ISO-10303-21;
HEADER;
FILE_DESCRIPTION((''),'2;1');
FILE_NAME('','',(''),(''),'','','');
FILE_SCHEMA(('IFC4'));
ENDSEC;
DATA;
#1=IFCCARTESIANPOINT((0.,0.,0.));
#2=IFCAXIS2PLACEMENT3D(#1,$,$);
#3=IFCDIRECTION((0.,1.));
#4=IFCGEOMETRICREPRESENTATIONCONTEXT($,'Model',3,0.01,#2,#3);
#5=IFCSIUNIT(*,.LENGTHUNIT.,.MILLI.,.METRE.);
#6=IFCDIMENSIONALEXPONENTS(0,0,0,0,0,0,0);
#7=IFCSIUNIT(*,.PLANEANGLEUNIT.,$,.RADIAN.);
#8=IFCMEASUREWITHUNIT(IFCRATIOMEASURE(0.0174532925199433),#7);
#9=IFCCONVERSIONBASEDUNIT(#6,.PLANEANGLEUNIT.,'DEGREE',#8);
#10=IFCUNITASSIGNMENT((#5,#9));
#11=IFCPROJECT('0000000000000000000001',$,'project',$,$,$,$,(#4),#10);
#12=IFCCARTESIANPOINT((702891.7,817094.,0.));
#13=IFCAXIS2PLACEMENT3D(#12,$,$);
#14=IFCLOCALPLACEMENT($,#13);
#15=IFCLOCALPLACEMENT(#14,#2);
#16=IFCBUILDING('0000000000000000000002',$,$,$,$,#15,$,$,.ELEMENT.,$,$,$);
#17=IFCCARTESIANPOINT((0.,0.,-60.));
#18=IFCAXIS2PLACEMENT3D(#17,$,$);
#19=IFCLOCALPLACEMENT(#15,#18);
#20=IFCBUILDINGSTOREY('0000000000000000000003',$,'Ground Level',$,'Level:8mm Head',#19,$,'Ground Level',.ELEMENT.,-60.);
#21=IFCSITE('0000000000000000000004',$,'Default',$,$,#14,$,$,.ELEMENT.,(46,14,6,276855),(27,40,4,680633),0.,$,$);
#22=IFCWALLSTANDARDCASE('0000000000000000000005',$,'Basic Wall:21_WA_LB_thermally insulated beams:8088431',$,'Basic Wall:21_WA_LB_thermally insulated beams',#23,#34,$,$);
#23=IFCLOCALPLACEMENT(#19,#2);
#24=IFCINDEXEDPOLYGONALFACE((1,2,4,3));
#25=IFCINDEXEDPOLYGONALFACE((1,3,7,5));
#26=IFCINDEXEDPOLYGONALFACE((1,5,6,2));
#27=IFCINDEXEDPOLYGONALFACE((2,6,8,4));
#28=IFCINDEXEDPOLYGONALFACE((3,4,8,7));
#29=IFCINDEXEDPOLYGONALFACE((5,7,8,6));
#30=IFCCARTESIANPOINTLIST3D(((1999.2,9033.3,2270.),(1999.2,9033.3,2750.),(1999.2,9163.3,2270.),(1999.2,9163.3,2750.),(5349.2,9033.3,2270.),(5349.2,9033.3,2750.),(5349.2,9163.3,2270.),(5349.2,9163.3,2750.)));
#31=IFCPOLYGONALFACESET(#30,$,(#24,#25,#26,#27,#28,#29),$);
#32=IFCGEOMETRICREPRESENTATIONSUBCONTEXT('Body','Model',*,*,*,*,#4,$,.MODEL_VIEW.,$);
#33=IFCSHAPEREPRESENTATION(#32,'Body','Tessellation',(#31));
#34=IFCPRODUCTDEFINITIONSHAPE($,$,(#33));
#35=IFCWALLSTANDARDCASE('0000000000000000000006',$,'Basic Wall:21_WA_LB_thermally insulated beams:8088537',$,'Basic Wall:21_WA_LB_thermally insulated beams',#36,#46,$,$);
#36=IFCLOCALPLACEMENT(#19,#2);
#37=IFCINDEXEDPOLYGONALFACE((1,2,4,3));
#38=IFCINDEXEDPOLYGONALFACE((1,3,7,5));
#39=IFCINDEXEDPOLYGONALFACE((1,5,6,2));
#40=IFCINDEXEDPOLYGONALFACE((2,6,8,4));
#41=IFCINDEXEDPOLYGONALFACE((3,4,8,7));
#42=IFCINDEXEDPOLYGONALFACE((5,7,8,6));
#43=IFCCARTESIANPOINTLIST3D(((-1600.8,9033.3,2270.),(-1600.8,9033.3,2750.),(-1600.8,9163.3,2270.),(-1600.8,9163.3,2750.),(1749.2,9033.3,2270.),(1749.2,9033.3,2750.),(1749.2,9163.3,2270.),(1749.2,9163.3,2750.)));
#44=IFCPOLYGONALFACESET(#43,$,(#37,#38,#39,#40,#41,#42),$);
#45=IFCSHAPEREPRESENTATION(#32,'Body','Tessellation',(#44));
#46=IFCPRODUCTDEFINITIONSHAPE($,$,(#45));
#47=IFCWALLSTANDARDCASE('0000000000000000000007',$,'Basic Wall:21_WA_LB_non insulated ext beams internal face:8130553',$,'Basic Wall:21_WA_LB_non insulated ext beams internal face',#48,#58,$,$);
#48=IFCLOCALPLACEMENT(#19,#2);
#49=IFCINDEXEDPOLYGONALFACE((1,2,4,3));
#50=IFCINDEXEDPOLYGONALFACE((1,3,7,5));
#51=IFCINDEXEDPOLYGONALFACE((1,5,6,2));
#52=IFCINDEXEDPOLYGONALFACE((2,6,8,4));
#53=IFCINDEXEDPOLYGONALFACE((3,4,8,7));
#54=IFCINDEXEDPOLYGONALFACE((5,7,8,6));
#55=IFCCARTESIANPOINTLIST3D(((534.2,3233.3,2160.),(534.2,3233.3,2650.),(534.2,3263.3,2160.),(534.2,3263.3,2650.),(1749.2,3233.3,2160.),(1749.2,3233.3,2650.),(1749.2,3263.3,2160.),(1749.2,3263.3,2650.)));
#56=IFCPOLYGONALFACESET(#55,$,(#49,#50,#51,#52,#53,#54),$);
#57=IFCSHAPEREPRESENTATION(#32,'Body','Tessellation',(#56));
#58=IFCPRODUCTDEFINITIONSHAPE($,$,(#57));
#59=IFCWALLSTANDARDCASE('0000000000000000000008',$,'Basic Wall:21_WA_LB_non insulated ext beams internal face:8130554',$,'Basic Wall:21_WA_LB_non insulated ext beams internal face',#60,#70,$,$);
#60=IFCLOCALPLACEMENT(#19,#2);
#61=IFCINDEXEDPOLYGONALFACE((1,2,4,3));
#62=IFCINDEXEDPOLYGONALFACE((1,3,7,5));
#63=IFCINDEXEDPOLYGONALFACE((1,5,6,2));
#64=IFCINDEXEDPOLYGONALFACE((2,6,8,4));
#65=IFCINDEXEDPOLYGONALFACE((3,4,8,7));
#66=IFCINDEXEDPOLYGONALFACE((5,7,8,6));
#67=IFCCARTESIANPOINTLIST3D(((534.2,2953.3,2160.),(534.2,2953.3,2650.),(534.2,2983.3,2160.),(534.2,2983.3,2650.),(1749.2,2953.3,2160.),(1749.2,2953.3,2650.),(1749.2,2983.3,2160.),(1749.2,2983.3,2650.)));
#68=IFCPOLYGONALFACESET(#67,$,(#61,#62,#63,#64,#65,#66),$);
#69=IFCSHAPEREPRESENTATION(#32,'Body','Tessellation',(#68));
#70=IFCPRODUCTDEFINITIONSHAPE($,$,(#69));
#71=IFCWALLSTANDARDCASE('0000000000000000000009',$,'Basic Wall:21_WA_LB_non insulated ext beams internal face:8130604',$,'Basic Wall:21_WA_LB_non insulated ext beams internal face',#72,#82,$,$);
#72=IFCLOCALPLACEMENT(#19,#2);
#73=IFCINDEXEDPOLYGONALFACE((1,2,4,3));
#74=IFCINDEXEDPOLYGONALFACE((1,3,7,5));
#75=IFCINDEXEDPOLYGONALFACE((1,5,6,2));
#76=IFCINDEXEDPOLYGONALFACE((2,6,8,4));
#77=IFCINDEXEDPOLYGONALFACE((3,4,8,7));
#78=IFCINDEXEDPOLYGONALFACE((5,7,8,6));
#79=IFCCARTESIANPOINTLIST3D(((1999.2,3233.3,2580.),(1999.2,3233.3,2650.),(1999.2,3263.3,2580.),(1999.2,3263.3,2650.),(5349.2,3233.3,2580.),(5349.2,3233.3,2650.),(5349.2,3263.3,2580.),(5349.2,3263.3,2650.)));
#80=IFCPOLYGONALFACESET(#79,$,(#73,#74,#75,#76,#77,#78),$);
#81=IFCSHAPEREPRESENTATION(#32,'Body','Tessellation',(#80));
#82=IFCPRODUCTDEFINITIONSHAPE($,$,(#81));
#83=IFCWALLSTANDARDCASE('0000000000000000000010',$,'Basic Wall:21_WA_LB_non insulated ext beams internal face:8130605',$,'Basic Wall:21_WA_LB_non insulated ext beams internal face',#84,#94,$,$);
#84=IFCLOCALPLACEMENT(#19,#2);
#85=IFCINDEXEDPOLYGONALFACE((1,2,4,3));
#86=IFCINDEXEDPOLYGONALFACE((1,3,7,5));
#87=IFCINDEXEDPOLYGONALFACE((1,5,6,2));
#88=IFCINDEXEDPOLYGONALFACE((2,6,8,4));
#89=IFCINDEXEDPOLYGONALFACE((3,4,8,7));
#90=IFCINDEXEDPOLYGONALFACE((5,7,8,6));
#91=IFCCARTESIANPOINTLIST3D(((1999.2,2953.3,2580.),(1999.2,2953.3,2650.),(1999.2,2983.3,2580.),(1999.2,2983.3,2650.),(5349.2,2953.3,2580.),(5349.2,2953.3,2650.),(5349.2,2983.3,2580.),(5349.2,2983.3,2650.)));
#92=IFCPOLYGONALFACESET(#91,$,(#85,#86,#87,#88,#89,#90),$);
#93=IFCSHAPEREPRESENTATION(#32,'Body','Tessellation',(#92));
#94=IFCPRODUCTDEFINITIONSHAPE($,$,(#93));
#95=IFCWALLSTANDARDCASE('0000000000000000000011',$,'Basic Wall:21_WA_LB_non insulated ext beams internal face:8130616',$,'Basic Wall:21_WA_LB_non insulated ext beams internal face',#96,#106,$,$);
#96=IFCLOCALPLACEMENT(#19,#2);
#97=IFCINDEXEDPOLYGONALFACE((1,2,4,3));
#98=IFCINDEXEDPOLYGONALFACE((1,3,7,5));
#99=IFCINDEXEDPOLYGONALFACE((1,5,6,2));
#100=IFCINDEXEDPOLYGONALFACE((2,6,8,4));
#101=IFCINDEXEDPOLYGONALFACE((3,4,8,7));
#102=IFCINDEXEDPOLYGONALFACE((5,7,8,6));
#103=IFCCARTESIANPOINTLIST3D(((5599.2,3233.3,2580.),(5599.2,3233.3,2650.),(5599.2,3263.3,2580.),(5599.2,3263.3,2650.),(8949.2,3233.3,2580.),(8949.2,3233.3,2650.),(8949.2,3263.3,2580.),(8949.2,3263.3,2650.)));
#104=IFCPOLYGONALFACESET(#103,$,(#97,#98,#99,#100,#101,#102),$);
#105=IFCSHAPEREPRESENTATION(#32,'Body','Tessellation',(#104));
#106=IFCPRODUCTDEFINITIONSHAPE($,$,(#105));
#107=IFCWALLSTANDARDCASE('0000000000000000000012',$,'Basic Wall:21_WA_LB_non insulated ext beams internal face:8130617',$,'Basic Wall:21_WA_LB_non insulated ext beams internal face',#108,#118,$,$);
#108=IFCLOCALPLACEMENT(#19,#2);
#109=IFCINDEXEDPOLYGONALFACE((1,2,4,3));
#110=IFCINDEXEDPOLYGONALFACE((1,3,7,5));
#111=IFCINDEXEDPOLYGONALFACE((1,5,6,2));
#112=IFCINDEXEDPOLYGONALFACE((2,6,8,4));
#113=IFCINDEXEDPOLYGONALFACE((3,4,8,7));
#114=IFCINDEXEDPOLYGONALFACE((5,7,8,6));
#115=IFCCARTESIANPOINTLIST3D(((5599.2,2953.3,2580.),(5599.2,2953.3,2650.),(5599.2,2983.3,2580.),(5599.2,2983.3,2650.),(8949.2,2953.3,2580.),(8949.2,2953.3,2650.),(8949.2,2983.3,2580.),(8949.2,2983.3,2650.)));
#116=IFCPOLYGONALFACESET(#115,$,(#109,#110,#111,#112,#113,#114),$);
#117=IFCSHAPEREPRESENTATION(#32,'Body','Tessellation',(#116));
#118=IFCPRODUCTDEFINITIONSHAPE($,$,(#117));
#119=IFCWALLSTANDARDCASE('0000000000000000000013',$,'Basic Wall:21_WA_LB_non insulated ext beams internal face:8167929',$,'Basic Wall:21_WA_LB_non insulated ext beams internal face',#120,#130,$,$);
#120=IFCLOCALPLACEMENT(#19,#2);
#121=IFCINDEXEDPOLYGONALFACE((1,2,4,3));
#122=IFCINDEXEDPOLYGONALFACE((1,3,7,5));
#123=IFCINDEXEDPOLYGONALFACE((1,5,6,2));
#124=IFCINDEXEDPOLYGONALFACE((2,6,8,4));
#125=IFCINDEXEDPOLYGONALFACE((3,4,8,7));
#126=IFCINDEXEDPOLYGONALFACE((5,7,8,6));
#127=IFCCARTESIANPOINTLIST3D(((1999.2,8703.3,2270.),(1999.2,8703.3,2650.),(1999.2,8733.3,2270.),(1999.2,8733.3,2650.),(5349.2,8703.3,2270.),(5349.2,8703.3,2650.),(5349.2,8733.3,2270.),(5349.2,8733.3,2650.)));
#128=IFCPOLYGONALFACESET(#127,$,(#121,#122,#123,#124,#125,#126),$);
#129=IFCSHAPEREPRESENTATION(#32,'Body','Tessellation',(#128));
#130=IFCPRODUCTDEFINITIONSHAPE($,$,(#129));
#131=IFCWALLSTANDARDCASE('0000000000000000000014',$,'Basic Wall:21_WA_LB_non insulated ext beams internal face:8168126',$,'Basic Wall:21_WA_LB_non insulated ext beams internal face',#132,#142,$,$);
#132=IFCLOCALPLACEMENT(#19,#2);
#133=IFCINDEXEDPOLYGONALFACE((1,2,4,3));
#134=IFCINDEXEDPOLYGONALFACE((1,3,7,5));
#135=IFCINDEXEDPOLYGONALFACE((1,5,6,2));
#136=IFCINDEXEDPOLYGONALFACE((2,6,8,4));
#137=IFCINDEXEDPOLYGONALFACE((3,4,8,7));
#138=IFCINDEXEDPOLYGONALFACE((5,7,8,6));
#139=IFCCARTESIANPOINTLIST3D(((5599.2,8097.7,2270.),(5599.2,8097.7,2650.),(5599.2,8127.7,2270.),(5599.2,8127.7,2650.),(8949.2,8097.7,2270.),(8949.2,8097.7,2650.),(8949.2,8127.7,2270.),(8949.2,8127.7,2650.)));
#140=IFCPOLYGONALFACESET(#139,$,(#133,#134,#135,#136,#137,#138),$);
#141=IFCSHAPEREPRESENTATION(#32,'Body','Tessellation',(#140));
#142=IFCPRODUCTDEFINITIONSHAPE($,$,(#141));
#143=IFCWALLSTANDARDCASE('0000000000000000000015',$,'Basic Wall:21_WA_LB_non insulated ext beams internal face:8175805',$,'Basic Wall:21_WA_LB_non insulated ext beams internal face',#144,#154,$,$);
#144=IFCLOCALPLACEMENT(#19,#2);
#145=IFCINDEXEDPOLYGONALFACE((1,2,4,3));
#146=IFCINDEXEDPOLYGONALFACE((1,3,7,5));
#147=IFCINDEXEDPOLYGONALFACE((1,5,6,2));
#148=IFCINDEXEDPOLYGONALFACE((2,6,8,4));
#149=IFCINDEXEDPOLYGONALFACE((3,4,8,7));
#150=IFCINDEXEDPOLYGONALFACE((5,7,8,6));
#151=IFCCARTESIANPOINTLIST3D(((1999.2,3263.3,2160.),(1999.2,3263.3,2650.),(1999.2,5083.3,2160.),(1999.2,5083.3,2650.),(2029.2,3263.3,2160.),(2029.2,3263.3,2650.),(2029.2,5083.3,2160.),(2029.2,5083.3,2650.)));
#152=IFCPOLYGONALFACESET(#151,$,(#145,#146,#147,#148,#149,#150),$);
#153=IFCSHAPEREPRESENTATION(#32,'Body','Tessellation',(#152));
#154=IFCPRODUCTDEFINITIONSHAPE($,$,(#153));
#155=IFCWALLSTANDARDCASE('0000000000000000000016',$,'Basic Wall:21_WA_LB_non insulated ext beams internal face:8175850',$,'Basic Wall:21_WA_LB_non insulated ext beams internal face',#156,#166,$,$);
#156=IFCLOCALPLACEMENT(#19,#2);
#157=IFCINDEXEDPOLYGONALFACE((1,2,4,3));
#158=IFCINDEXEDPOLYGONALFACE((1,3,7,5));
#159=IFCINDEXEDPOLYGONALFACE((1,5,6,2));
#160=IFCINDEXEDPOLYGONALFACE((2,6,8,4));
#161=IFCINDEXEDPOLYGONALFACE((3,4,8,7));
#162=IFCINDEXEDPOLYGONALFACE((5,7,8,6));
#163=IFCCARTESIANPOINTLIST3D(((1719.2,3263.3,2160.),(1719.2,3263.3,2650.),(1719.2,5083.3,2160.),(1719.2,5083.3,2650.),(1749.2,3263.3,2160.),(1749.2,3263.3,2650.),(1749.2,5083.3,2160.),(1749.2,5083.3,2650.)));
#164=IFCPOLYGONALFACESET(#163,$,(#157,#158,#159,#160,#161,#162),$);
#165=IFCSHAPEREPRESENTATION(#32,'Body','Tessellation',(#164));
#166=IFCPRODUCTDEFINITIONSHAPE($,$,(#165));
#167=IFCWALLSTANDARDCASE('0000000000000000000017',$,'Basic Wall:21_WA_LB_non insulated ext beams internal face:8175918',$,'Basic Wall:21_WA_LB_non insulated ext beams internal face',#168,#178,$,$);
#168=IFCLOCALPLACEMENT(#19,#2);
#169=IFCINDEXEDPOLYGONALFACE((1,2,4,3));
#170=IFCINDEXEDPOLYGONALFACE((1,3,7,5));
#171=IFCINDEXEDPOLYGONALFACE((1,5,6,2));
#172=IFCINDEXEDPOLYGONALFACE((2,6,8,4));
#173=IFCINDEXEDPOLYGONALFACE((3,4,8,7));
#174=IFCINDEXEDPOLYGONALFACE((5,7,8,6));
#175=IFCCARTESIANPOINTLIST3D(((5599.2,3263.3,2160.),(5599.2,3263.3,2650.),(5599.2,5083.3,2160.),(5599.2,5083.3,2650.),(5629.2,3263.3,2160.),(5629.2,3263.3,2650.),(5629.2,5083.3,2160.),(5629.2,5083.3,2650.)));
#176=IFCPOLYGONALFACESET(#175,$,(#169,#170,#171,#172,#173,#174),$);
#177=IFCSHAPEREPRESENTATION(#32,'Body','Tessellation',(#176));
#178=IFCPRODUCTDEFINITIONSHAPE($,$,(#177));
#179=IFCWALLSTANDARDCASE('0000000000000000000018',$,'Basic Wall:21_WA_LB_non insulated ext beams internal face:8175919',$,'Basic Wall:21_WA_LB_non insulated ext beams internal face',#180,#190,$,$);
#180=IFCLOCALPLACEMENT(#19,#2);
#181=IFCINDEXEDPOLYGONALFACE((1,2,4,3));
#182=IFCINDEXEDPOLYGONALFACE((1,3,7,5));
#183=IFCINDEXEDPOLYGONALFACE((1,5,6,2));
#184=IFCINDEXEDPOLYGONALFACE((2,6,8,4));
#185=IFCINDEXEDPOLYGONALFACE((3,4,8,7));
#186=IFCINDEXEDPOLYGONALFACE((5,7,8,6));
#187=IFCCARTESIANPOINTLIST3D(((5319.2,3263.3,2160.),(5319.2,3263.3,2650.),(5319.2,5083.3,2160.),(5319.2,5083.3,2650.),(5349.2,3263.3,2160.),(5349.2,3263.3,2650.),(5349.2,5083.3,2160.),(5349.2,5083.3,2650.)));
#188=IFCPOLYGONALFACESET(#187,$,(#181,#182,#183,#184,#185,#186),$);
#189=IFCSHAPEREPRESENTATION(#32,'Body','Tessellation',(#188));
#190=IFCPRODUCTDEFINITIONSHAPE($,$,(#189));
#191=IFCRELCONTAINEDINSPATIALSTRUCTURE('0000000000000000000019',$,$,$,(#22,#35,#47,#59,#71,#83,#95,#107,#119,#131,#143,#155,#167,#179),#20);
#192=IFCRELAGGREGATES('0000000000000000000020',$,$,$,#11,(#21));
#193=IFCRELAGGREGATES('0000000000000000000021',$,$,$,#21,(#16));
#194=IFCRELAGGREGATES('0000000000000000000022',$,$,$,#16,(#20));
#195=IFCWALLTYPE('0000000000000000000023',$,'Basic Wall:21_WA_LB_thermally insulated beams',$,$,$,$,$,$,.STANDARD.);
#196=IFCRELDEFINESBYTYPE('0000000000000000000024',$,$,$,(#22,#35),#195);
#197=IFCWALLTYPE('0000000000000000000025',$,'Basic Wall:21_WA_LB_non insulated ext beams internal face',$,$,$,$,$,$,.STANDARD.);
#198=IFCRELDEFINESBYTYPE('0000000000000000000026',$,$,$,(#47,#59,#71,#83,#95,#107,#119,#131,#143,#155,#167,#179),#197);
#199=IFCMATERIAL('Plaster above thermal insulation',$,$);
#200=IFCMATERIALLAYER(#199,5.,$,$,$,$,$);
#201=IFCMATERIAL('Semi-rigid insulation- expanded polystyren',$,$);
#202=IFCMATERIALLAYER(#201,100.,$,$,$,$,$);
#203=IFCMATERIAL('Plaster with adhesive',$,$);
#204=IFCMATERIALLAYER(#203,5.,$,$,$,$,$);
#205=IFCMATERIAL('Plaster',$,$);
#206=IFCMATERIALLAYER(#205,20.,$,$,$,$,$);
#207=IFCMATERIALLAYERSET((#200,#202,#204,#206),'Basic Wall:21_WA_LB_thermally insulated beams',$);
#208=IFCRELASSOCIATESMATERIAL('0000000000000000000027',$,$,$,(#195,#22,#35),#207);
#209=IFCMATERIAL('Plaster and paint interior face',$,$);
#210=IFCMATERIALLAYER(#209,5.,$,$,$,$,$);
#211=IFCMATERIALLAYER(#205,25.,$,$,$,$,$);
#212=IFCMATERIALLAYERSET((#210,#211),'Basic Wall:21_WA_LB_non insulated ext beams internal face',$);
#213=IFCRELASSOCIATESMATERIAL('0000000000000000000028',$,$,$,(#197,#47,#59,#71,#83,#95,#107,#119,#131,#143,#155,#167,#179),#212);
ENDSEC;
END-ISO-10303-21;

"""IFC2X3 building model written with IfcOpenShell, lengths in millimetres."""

from ifc_helpers import new_model, entity, si_unit, converted_unit, direction, frame, frame_2d, origin, place, context, subcontext, project, spatial, rectangle, extrude, material, layer, layer_set, layer_usage, type_object, element, save


model = new_model("IFC2X3")

# Units and contexts
model_context = context("Model", 3, precision=0.01, world=origin(), true_north=direction((0.0, 1.0)))
body_context = subcontext(model_context, "Body", "Model", "MODEL_VIEW")
ifc_project = project(units=[si_unit("LENGTHUNIT", "METRE", prefix="MILLI"), converted_unit("PLANEANGLEUNIT", "DEGREE", entity("IfcRatioMeasure", 0.0174532925199433), si_unit("PLANEANGLEUNIT", "RADIAN"), dimensions=[0, 0, 0, 0, 0, 0, 0])], contexts=[model_context])

# Site, building, storey
site_placement = place(None, frame((702891.7, 817094.0, 0.0)))
site = spatial("IfcSite", under=ifc_project, at=site_placement, Name="Default", CompositionType="ELEMENT", RefLatitude=(46, 14, 6, 276855), RefLongitude=(27, 40, 4, 680633), RefElevation=0.0)
building_placement = place(site_placement, origin())
building = spatial("IfcBuilding", under=site, at=building_placement, CompositionType="ELEMENT")
storey_placement = place(building_placement, frame((0.0, 0.0, -60.0)))
storey = spatial("IfcBuildingStorey", under=building, at=storey_placement, Name="Ground Level", ObjectType="Level:8mm Head", LongName="Ground Level", CompositionType="ELEMENT", Elevation=-60.0)

# Walls
ifc_material_1 = material(Name="Plaster above thermal insulation")
ifc_layer_1 = layer(ifc_material_1, 5.0)
ifc_material_2 = material(Name="Semi-rigid insulation- expanded polystyren")
ifc_layer_2 = layer(ifc_material_2, 100.0)
ifc_material_3 = material(Name="Plaster with adhesive")
ifc_layer_3 = layer(ifc_material_3, 5.0)
ifc_material_4 = material(Name="Plaster")
ifc_layer_4 = layer(ifc_material_4, 20.0)
ifc_layer_set_1 = layer_set([ifc_layer_1, ifc_layer_2, ifc_layer_3, ifc_layer_4], Name="Basic Wall:21_WA_LB_thermally insulated beams")
ifc_layer_usage_1 = layer_usage(ifc_layer_set_1, "AXIS2", "POSITIVE", -65.0)
wall_type_1 = type_object("IfcWallType", Name="Basic Wall:21_WA_LB_thermally insulated beams", PredefinedType="STANDARD", material=ifc_layer_set_1)
wall_1_placement = place(storey_placement, frame((5349.2, 9098.3, 2270.0), z_axis=(0.0, 0.0, 1.0), x_axis=(-1.0, 0.0, 0.0)))
element("IfcWallStandardCase", 1, at=wall_1_placement, inside=storey, type_object=wall_type_1, material=ifc_layer_usage_1, Name="Basic Wall:21_WA_LB_thermally insulated beams:8088431", ObjectType="Basic Wall:21_WA_LB_thermally insulated beams", context=body_context, shape_type="SweptSolid", body=[
    extrude(rectangle(XDim=3350.0, YDim=130.0, at=frame_2d((1675.0, 0.0), x_axis=(-1.0, 0.0))), origin(), (0.0, 0.0, 1.0), 480.0),
])
ifc_layer_usage_2 = layer_usage(ifc_layer_set_1, "AXIS2", "POSITIVE", -65.0)
wall_2_placement = place(storey_placement, frame((1749.2, 9098.3, 2270.0), z_axis=(0.0, 0.0, 1.0), x_axis=(-1.0, 0.0, 0.0)))
element("IfcWallStandardCase", 2, at=wall_2_placement, inside=storey, type_object=wall_type_1, material=ifc_layer_usage_2, Name="Basic Wall:21_WA_LB_thermally insulated beams:8088537", ObjectType="Basic Wall:21_WA_LB_thermally insulated beams", context=body_context, shape_type="SweptSolid", body=[
    extrude(rectangle(XDim=3350.0, YDim=130.0, at=frame_2d((1675.0, 0.0), x_axis=(-1.0, 0.0))), origin(), (0.0, 0.0, 1.0), 480.0),
])
ifc_material_5 = material(Name="Plaster and paint interior face")
ifc_layer_5 = layer(ifc_material_5, 5.0)
ifc_layer_6 = layer(ifc_material_4, 25.0)
ifc_layer_set_2 = layer_set([ifc_layer_5, ifc_layer_6], Name="Basic Wall:21_WA_LB_non insulated ext beams internal face")
ifc_layer_usage_3 = layer_usage(ifc_layer_set_2, "AXIS2", "NEGATIVE", 15.0)
wall_type_2 = type_object("IfcWallType", Name="Basic Wall:21_WA_LB_non insulated ext beams internal face", PredefinedType="STANDARD", material=ifc_layer_set_2)
wall_3_placement = place(storey_placement, frame((534.2, 3248.3, 2160.0)))
element("IfcWallStandardCase", 3, at=wall_3_placement, inside=storey, type_object=wall_type_2, material=ifc_layer_usage_3, Name="Basic Wall:21_WA_LB_non insulated ext beams internal face:8130553", ObjectType="Basic Wall:21_WA_LB_non insulated ext beams internal face", context=body_context, shape_type="SweptSolid", body=[
    extrude(rectangle(XDim=1215.0, YDim=30.0, at=frame_2d((607.5, 0.0), x_axis=(-1.0, 0.0))), origin(), (0.0, 0.0, 1.0), 490.0),
])
ifc_layer_usage_4 = layer_usage(ifc_layer_set_2, "AXIS2", "POSITIVE", -15.0)
wall_4_placement = place(storey_placement, frame((534.2, 2968.3, 2160.0)))
element("IfcWallStandardCase", 4, at=wall_4_placement, inside=storey, type_object=wall_type_2, material=ifc_layer_usage_4, Name="Basic Wall:21_WA_LB_non insulated ext beams internal face:8130554", ObjectType="Basic Wall:21_WA_LB_non insulated ext beams internal face", context=body_context, shape_type="SweptSolid", body=[
    extrude(rectangle(XDim=1215.0, YDim=30.0, at=frame_2d((607.5, 0.0), x_axis=(-1.0, 0.0))), origin(), (0.0, 0.0, 1.0), 490.0),
])
ifc_layer_usage_5 = layer_usage(ifc_layer_set_2, "AXIS2", "NEGATIVE", 15.0)
wall_5_placement = place(storey_placement, frame((1999.2, 3248.3, 2580.0)))
element("IfcWallStandardCase", 5, at=wall_5_placement, inside=storey, type_object=wall_type_2, material=ifc_layer_usage_5, Name="Basic Wall:21_WA_LB_non insulated ext beams internal face:8130604", ObjectType="Basic Wall:21_WA_LB_non insulated ext beams internal face", context=body_context, shape_type="SweptSolid", body=[
    extrude(rectangle(XDim=3350.0, YDim=30.0, at=frame_2d((1675.0, 0.0), x_axis=(-1.0, 0.0))), origin(), (0.0, 0.0, 1.0), 70.0),
])
ifc_layer_usage_6 = layer_usage(ifc_layer_set_2, "AXIS2", "POSITIVE", -15.0)
wall_6_placement = place(storey_placement, frame((1999.2, 2968.3, 2580.0)))
element("IfcWallStandardCase", 6, at=wall_6_placement, inside=storey, type_object=wall_type_2, material=ifc_layer_usage_6, Name="Basic Wall:21_WA_LB_non insulated ext beams internal face:8130605", ObjectType="Basic Wall:21_WA_LB_non insulated ext beams internal face", context=body_context, shape_type="SweptSolid", body=[
    extrude(rectangle(XDim=3350.0, YDim=30.0, at=frame_2d((1675.0, 0.0), x_axis=(-1.0, 0.0))), origin(), (0.0, 0.0, 1.0), 70.0),
])
ifc_layer_usage_7 = layer_usage(ifc_layer_set_2, "AXIS2", "NEGATIVE", 15.0)
wall_7_placement = place(storey_placement, frame((5599.2, 3248.3, 2580.0)))
element("IfcWallStandardCase", 7, at=wall_7_placement, inside=storey, type_object=wall_type_2, material=ifc_layer_usage_7, Name="Basic Wall:21_WA_LB_non insulated ext beams internal face:8130616", ObjectType="Basic Wall:21_WA_LB_non insulated ext beams internal face", context=body_context, shape_type="SweptSolid", body=[
    extrude(rectangle(XDim=3350.0, YDim=30.0, at=frame_2d((1675.0, 0.0), x_axis=(-1.0, 0.0))), origin(), (0.0, 0.0, 1.0), 70.0),
])
ifc_layer_usage_8 = layer_usage(ifc_layer_set_2, "AXIS2", "POSITIVE", -15.0)
wall_8_placement = place(storey_placement, frame((5599.2, 2968.3, 2580.0)))
element("IfcWallStandardCase", 8, at=wall_8_placement, inside=storey, type_object=wall_type_2, material=ifc_layer_usage_8, Name="Basic Wall:21_WA_LB_non insulated ext beams internal face:8130617", ObjectType="Basic Wall:21_WA_LB_non insulated ext beams internal face", context=body_context, shape_type="SweptSolid", body=[
    extrude(rectangle(XDim=3350.0, YDim=30.0, at=frame_2d((1675.0, 0.0), x_axis=(-1.0, 0.0))), origin(), (0.0, 0.0, 1.0), 70.0),
])
ifc_layer_usage_9 = layer_usage(ifc_layer_set_2, "AXIS2", "POSITIVE", -15.0)
wall_9_placement = place(storey_placement, frame((1999.2, 8718.3, 2270.0)))
element("IfcWallStandardCase", 9, at=wall_9_placement, inside=storey, type_object=wall_type_2, material=ifc_layer_usage_9, Name="Basic Wall:21_WA_LB_non insulated ext beams internal face:8167929", ObjectType="Basic Wall:21_WA_LB_non insulated ext beams internal face", context=body_context, shape_type="SweptSolid", body=[
    extrude(rectangle(XDim=3350.0, YDim=30.0, at=frame_2d((1675.0, 0.0), x_axis=(-1.0, 0.0))), origin(), (0.0, 0.0, 1.0), 380.0),
])
ifc_layer_usage_10 = layer_usage(ifc_layer_set_2, "AXIS2", "POSITIVE", -15.0)
wall_10_placement = place(storey_placement, frame((5599.2, 8112.7, 2270.0)))
element("IfcWallStandardCase", 10, at=wall_10_placement, inside=storey, type_object=wall_type_2, material=ifc_layer_usage_10, Name="Basic Wall:21_WA_LB_non insulated ext beams internal face:8168126", ObjectType="Basic Wall:21_WA_LB_non insulated ext beams internal face", context=body_context, shape_type="SweptSolid", body=[
    extrude(rectangle(XDim=3350.0, YDim=30.0, at=frame_2d((1675.0, 0.0), x_axis=(-1.0, 0.0))), origin(), (0.0, 0.0, 1.0), 380.0),
])
ifc_layer_usage_11 = layer_usage(ifc_layer_set_2, "AXIS2", "NEGATIVE", 15.0)
wall_11_placement = place(storey_placement, frame((2014.2, 5083.3, 2160.0), z_axis=(0.0, 0.0, 1.0), x_axis=(0.0, -1.0, 0.0)))
element("IfcWallStandardCase", 11, at=wall_11_placement, inside=storey, type_object=wall_type_2, material=ifc_layer_usage_11, Name="Basic Wall:21_WA_LB_non insulated ext beams internal face:8175805", ObjectType="Basic Wall:21_WA_LB_non insulated ext beams internal face", context=body_context, shape_type="SweptSolid", body=[
    extrude(rectangle(XDim=1820.0, YDim=30.0, at=frame_2d((910.0, 0.0), x_axis=(-1.0, 0.0))), origin(), (0.0, 0.0, 1.0), 490.0),
])
ifc_layer_usage_12 = layer_usage(ifc_layer_set_2, "AXIS2", "POSITIVE", -15.0)
wall_12_placement = place(storey_placement, frame((1734.2, 5083.3, 2160.0), z_axis=(0.0, 0.0, 1.0), x_axis=(0.0, -1.0, 0.0)))
element("IfcWallStandardCase", 12, at=wall_12_placement, inside=storey, type_object=wall_type_2, material=ifc_layer_usage_12, Name="Basic Wall:21_WA_LB_non insulated ext beams internal face:8175850", ObjectType="Basic Wall:21_WA_LB_non insulated ext beams internal face", context=body_context, shape_type="SweptSolid", body=[
    extrude(rectangle(XDim=1820.0, YDim=30.0, at=frame_2d((910.0, 0.0), x_axis=(-1.0, 0.0))), origin(), (0.0, 0.0, 1.0), 490.0),
])
ifc_layer_usage_13 = layer_usage(ifc_layer_set_2, "AXIS2", "NEGATIVE", 15.0)
wall_13_placement = place(storey_placement, frame((5614.2, 5083.3, 2160.0), z_axis=(0.0, 0.0, 1.0), x_axis=(0.0, -1.0, 0.0)))
element("IfcWallStandardCase", 13, at=wall_13_placement, inside=storey, type_object=wall_type_2, material=ifc_layer_usage_13, Name="Basic Wall:21_WA_LB_non insulated ext beams internal face:8175918", ObjectType="Basic Wall:21_WA_LB_non insulated ext beams internal face", context=body_context, shape_type="SweptSolid", body=[
    extrude(rectangle(XDim=1820.0, YDim=30.0, at=frame_2d((910.0, 0.0), x_axis=(-1.0, 0.0))), origin(), (0.0, 0.0, 1.0), 490.0),
])
ifc_layer_usage_14 = layer_usage(ifc_layer_set_2, "AXIS2", "POSITIVE", -15.0)
wall_14_placement = place(storey_placement, frame((5334.2, 5083.3, 2160.0), z_axis=(0.0, 0.0, 1.0), x_axis=(0.0, -1.0, 0.0)))
element("IfcWallStandardCase", 14, at=wall_14_placement, inside=storey, type_object=wall_type_2, material=ifc_layer_usage_14, Name="Basic Wall:21_WA_LB_non insulated ext beams internal face:8175919", ObjectType="Basic Wall:21_WA_LB_non insulated ext beams internal face", context=body_context, shape_type="SweptSolid", body=[
    extrude(rectangle(XDim=1820.0, YDim=30.0, at=frame_2d((910.0, 0.0), x_axis=(-1.0, 0.0))), origin(), (0.0, 0.0, 1.0), 490.0),
])

save(model, "model.ifc")
